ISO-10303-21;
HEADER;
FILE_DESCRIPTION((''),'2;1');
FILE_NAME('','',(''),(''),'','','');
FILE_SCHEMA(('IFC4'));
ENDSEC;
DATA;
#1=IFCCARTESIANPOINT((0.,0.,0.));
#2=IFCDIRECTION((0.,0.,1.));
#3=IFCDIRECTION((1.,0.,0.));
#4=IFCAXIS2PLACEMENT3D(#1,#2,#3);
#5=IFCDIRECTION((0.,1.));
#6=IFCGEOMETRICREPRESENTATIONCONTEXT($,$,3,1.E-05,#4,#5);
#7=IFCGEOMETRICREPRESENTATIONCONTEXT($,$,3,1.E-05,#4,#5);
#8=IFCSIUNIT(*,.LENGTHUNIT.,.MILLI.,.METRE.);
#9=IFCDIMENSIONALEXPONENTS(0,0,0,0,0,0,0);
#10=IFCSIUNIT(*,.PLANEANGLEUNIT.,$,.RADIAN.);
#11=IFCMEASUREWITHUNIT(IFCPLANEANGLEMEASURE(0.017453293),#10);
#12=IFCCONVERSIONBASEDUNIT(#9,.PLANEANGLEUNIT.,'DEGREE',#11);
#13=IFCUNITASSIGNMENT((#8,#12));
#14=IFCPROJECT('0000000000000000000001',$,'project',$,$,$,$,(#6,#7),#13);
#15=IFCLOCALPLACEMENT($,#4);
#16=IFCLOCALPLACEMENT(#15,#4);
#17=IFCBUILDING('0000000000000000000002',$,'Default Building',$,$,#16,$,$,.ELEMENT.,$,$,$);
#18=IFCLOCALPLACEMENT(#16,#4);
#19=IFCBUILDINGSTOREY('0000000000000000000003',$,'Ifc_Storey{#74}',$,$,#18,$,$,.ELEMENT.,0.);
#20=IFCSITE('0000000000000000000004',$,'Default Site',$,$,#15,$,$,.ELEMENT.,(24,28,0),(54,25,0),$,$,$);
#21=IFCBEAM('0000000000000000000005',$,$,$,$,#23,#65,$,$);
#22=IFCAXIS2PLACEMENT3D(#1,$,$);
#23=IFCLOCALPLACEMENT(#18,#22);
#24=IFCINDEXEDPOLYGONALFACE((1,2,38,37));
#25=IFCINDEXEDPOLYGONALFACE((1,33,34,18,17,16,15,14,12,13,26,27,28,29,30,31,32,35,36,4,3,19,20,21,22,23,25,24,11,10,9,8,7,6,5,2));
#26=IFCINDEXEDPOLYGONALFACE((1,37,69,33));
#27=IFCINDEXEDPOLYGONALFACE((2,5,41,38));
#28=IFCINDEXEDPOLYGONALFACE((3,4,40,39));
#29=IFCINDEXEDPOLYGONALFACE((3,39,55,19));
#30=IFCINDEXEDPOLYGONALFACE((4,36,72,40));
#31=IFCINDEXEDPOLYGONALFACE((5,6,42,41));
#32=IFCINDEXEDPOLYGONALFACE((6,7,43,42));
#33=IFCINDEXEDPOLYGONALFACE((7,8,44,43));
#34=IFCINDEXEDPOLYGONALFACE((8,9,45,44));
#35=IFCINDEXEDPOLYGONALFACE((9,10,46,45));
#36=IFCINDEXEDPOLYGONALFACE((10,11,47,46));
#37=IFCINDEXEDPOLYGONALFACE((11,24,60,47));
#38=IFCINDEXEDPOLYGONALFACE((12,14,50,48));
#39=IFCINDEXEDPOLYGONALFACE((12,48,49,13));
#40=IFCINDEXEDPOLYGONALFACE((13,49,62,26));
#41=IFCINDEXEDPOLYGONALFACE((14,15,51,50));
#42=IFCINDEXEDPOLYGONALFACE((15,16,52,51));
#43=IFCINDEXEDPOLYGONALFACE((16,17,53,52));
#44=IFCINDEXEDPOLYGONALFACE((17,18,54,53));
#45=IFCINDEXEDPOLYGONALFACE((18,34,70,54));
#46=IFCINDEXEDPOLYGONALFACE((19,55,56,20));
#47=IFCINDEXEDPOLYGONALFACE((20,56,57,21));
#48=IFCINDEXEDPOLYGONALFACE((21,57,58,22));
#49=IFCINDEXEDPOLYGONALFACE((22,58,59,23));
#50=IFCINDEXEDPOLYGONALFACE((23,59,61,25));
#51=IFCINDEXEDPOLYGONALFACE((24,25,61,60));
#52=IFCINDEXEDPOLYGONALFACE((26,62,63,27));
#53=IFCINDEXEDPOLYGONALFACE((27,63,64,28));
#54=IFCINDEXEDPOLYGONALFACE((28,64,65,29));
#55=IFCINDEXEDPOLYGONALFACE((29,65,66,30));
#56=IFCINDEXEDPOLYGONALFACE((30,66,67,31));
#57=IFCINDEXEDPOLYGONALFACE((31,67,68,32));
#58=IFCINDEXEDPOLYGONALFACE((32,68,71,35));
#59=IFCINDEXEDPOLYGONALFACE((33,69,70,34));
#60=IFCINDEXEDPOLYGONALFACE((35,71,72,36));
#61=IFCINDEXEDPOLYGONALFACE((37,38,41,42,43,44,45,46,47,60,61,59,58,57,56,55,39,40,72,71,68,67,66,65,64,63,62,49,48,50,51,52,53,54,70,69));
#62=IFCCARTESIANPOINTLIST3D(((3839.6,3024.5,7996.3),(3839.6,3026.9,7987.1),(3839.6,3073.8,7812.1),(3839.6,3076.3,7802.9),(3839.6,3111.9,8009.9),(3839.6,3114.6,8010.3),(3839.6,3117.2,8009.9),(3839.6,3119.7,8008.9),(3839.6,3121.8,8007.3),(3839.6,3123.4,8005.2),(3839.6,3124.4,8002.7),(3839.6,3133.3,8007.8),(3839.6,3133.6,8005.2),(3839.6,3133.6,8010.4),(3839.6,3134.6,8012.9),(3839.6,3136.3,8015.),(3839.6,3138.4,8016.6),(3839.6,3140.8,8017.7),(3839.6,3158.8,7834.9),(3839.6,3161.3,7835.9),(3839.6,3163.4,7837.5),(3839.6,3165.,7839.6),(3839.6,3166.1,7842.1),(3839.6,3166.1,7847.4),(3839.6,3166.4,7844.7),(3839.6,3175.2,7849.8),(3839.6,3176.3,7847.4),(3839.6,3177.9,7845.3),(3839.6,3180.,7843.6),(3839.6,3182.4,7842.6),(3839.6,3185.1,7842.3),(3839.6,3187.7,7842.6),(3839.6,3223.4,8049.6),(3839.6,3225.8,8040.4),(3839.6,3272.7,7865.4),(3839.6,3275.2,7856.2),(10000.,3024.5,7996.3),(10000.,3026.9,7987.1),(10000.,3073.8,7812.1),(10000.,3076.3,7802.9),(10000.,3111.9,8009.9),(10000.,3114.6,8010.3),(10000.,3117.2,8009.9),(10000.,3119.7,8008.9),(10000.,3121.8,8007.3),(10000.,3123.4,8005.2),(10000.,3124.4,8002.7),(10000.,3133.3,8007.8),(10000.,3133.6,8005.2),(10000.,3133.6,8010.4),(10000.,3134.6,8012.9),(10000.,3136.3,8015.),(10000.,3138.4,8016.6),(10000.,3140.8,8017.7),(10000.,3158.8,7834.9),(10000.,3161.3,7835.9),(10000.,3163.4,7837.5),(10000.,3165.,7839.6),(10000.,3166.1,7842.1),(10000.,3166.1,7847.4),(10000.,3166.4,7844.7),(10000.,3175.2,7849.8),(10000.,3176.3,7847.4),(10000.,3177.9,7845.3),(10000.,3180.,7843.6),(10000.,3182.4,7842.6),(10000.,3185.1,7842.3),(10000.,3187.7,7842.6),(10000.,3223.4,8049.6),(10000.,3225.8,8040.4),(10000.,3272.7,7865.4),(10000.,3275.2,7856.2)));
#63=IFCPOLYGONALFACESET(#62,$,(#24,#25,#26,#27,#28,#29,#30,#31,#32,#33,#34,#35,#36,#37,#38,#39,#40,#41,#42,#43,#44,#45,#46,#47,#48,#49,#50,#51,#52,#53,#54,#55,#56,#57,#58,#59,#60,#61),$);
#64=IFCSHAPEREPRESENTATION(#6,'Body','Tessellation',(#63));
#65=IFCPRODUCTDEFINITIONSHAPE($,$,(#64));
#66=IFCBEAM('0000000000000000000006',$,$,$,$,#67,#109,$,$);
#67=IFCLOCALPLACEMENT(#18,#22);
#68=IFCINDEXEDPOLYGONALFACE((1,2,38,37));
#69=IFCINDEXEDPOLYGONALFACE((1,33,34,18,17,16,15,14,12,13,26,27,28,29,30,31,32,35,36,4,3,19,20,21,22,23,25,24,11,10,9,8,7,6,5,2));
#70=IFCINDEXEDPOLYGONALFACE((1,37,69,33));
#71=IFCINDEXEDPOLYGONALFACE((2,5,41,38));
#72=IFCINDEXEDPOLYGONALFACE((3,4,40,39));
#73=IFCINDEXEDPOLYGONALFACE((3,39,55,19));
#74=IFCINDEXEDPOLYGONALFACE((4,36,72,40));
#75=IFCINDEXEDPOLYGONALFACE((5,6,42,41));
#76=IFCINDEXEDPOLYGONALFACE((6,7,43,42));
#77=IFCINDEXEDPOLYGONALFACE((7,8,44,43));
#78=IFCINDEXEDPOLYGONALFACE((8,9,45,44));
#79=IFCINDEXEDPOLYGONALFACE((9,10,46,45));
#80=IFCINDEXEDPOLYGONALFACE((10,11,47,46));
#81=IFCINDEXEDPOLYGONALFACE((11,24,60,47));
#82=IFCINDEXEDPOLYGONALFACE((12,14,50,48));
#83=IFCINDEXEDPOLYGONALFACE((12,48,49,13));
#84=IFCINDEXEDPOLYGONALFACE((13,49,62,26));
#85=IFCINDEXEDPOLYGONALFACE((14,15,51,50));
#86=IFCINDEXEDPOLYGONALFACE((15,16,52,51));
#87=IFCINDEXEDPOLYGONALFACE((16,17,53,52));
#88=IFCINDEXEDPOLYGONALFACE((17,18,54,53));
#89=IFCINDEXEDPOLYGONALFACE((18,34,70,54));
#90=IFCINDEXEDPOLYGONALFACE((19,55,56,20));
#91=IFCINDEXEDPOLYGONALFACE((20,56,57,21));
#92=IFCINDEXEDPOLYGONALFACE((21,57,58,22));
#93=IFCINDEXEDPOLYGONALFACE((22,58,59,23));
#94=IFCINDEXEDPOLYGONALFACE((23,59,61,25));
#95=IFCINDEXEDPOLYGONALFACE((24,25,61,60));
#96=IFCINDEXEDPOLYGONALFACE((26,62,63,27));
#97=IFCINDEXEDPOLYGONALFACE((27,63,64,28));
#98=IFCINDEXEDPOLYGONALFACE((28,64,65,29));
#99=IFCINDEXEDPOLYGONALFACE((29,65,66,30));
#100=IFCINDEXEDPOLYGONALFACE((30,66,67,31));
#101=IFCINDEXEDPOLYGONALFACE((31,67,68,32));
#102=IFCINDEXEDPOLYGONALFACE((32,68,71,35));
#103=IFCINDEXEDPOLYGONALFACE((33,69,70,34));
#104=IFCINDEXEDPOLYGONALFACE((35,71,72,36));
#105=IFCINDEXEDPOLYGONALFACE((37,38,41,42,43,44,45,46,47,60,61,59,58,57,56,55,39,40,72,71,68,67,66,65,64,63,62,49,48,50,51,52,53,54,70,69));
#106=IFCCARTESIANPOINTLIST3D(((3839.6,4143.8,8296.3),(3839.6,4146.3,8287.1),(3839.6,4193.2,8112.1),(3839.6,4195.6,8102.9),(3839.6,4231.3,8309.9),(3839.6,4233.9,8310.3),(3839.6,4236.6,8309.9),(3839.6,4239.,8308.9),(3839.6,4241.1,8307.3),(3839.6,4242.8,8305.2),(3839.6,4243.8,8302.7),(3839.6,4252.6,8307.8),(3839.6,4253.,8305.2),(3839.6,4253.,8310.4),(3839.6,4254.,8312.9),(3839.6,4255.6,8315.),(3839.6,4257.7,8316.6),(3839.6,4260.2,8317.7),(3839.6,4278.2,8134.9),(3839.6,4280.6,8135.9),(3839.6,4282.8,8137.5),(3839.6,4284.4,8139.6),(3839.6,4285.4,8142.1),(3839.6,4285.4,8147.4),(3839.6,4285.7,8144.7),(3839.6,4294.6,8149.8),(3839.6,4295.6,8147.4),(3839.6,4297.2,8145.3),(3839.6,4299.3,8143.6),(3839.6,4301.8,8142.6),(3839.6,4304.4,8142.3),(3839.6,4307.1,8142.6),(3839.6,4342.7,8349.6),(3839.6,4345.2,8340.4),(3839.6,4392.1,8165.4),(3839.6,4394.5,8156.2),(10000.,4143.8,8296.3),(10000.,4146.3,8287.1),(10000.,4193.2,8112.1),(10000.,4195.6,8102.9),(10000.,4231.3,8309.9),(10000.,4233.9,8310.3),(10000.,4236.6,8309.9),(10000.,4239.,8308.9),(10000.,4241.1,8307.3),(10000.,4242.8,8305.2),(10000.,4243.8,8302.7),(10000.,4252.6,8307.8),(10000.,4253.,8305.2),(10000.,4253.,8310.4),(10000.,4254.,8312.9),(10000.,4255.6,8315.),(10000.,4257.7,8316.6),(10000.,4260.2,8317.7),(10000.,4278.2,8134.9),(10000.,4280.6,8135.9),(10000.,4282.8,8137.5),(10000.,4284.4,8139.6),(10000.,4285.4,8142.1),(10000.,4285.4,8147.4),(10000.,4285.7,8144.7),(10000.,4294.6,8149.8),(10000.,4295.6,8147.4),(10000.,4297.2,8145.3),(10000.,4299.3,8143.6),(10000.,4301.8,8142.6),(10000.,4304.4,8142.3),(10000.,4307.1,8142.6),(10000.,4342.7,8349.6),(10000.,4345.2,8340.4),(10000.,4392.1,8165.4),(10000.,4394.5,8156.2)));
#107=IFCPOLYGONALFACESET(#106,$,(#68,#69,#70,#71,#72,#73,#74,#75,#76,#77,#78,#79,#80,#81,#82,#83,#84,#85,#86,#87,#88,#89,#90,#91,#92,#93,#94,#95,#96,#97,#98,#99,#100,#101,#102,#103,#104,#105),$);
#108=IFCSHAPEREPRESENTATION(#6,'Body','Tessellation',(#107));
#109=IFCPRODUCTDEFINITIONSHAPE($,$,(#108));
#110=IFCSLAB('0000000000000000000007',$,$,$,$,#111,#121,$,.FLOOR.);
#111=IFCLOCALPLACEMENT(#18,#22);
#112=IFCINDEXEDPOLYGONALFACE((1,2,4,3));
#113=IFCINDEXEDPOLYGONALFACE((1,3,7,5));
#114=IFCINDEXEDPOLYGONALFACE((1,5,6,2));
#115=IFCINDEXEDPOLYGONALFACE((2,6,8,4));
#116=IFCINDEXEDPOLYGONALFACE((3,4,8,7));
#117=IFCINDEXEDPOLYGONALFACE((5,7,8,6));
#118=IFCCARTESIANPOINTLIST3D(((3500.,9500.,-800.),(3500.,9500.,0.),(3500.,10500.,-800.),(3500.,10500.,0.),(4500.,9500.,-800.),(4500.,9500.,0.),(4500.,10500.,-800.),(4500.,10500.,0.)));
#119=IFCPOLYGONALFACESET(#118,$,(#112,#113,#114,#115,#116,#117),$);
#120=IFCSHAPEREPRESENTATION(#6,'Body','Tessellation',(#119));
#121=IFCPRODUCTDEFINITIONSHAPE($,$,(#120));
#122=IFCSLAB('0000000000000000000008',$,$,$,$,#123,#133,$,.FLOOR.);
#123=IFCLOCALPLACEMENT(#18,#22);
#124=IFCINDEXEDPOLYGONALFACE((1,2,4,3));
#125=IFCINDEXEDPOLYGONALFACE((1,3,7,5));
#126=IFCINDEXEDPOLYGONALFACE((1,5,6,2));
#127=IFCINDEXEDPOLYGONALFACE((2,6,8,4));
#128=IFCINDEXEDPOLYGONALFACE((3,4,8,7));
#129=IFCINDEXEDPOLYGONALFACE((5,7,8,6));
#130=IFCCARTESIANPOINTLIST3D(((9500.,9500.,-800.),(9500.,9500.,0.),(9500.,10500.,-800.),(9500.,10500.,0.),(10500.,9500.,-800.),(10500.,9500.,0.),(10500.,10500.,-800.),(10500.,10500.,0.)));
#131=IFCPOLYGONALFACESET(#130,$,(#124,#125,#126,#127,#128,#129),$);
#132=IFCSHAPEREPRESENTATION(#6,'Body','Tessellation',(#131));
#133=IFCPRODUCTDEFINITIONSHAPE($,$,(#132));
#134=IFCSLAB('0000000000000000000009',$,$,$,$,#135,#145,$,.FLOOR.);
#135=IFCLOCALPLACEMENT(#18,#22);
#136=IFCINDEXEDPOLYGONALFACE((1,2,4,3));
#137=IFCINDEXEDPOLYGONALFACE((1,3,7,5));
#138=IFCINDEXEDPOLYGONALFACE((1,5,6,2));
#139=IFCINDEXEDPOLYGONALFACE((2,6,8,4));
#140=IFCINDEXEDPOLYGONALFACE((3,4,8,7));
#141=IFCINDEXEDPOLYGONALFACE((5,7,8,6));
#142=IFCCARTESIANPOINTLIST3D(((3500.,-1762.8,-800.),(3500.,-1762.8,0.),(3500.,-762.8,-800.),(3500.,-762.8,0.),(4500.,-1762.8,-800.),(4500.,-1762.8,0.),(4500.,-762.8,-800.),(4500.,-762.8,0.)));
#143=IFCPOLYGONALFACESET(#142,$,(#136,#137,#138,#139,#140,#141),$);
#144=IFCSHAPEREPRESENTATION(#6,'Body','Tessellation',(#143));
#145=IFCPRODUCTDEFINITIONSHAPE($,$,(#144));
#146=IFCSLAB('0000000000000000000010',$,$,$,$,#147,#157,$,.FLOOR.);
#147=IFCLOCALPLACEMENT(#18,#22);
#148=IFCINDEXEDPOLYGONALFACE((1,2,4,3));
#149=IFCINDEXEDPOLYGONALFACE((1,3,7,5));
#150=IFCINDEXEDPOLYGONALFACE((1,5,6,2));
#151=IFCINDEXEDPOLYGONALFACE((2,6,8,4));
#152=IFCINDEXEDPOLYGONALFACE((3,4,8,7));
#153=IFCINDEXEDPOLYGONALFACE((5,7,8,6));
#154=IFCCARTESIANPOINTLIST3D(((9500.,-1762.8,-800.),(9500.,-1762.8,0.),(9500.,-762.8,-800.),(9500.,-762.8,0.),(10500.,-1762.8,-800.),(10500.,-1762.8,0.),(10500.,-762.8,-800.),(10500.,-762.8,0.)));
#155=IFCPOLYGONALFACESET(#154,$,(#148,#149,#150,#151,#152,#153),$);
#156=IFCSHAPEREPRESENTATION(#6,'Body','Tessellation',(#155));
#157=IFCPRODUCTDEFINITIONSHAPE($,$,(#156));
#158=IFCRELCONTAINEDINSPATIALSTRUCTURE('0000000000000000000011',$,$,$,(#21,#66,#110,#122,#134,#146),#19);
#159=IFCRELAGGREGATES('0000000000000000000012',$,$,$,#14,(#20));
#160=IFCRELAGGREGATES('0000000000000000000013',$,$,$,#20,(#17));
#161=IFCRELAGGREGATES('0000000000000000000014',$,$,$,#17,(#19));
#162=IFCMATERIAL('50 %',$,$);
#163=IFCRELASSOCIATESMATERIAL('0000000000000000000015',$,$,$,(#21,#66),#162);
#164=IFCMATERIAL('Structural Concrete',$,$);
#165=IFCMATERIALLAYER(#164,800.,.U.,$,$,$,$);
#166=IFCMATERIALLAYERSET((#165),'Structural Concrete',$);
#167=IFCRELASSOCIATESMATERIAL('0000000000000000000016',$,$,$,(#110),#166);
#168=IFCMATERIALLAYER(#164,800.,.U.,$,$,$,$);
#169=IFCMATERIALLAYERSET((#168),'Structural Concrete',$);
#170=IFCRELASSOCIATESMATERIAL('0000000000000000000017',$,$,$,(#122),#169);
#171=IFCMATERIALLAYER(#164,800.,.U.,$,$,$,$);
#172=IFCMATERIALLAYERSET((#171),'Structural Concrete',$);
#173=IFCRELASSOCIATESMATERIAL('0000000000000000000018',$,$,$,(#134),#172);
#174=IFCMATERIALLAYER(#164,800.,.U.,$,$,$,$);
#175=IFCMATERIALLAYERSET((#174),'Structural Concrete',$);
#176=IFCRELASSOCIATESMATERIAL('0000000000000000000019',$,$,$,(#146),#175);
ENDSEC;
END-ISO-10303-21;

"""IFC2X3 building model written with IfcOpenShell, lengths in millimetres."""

from ifc_helpers import new_model, entity, si_unit, converted_unit, direction, frame, origin_with_axes, origin_2d_with_axis, place, context, project, spatial, polyline, i_section, outline, extrude, material, layer, layer_set, layer_usage, element, save


model = new_model("IFC2X3")

# Units and contexts
context_of_model_1 = context(None, 3, precision=1e-05, world=origin_with_axes(), true_north=direction((0.0, 1.0)))
context_of_model_2 = context(None, 3, precision=1e-05, world=origin_with_axes(), true_north=direction((0.0, 1.0)))
ifc_project = project(units=[si_unit("LENGTHUNIT", "METRE", prefix="MILLI"), converted_unit("PLANEANGLEUNIT", "DEGREE", entity("IfcPlaneAngleMeasure", 0.017453293), si_unit("PLANEANGLEUNIT", "RADIAN"), dimensions=[0, 0, 0, 0, 0, 0, 0])], contexts=[context_of_model_1, context_of_model_2])

# Site, building, storey
site_placement = place(None, origin_with_axes())
site = spatial("IfcSite", under=ifc_project, at=site_placement, Name="Default Site", CompositionType="ELEMENT", RefLatitude=(24, 28, 0), RefLongitude=(54, 25, 0))
building_placement = place(site_placement, origin_with_axes())
building = spatial("IfcBuilding", under=site, at=building_placement, Name="Default Building", CompositionType="ELEMENT")
storey_placement = place(building_placement, origin_with_axes())
storey = spatial("IfcBuildingStorey", under=building, at=storey_placement, Name="Ifc_Storey{#74}", CompositionType="ELEMENT", Elevation=0.0)

# Shared definitions
ifc_material_1 = material(Name="50 %")

# Beams
for number, where, z_axis, x_axis in (
    (1, (3839.6, 3149.8, 7926.3), (0.0, -0.258819, 0.965926), (-1.0, 0.0, 0.0)),
    (2, (3839.6, 4269.2, 8226.3), (0.0, -0.258819, 0.965926), (-1.0, 0.0, 0.0)),
):
    element("IfcBeam", number, at=place(storey_placement, frame(where, z_axis=z_axis, x_axis=x_axis)), inside=storey, material=ifc_material_1, context=context_of_model_1, shape_type="SweptSolid", body=[
        extrude(i_section(OverallWidth=205.9, OverallDepth=200.2, WebThickness=9.5, FlangeThickness=9.5, FilletRadius=10.2, at=origin_2d_with_axis()), frame((0.0, 0.0, 0.0), z_axis=(-1.0, 0.0, 0.0), x_axis=(0.0, 1.0, 0.0)), (0.0, 0.0, 1.0), 6160.4),
    ])

# Slabs
ifc_material_2 = material(Name="Structural Concrete")
ifc_layer_1 = layer(ifc_material_2, 800.0, ventilated="UNKNOWN")
ifc_layer_set_1 = layer_set([ifc_layer_1], Name="Structural Concrete")
ifc_layer_usage_1 = layer_usage(ifc_layer_set_1, "AXIS3", "NEGATIVE", 800.0)
slab_1_placement = place(storey_placement, frame((3500.0, 10500.0, -800.0), z_axis=(0.0, 0.0, 1.0), x_axis=(0.0, -1.0, 0.0)))
element("IfcSlab", 3, at=slab_1_placement, inside=storey, material=ifc_layer_usage_1, PredefinedType="FLOOR", context=context_of_model_1, shape_type="SweptSolid", body=[
    extrude(outline(polyline([(0.0, 0.0), (1000.0, 0.0), (1000.0, 1000.0), (0.0, 1000.0), (0.0, 0.0)])), origin_with_axes(), (0.0, 0.0, 1.0), 800.0),
])
ifc_layer_2 = layer(ifc_material_2, 800.0, ventilated="UNKNOWN")
ifc_layer_set_2 = layer_set([ifc_layer_2], Name="Structural Concrete")
ifc_layer_usage_2 = layer_usage(ifc_layer_set_2, "AXIS3", "NEGATIVE", 800.0)
slab_2_placement = place(storey_placement, frame((9500.0, 10500.0, -800.0), z_axis=(0.0, 0.0, 1.0), x_axis=(0.0, -1.0, 0.0)))
element("IfcSlab", 4, at=slab_2_placement, inside=storey, material=ifc_layer_usage_2, PredefinedType="FLOOR", context=context_of_model_1, shape_type="SweptSolid", body=[
    extrude(outline(polyline([(0.0, 0.0), (1000.0, 0.0), (1000.0, 1000.0), (0.0, 1000.0), (0.0, 0.0)])), origin_with_axes(), (0.0, 0.0, 1.0), 800.0),
])
ifc_layer_3 = layer(ifc_material_2, 800.0, ventilated="UNKNOWN")
ifc_layer_set_3 = layer_set([ifc_layer_3], Name="Structural Concrete")
ifc_layer_usage_3 = layer_usage(ifc_layer_set_3, "AXIS3", "NEGATIVE", 800.0)
slab_3_placement = place(storey_placement, frame((3500.0, -1762.8, -800.0), z_axis=(0.0, 0.0, 1.0), x_axis=(0.0, 1.0, 0.0)))
element("IfcSlab", 5, at=slab_3_placement, inside=storey, material=ifc_layer_usage_3, PredefinedType="FLOOR", context=context_of_model_1, shape_type="SweptSolid", body=[
    extrude(outline(polyline([(0.0, 0.0), (1000.0, 0.0), (1000.0, -1000.0), (0.0, -1000.0), (0.0, 0.0)])), origin_with_axes(), (0.0, 0.0, 1.0), 800.0),
])
ifc_layer_4 = layer(ifc_material_2, 800.0, ventilated="UNKNOWN")
ifc_layer_set_4 = layer_set([ifc_layer_4], Name="Structural Concrete")
ifc_layer_usage_4 = layer_usage(ifc_layer_set_4, "AXIS3", "NEGATIVE", 800.0)
slab_4_placement = place(storey_placement, frame((9500.0, -1762.8, -800.0), z_axis=(0.0, 0.0, 1.0), x_axis=(0.0, 1.0, 0.0)))
element("IfcSlab", 6, at=slab_4_placement, inside=storey, material=ifc_layer_usage_4, PredefinedType="FLOOR", context=context_of_model_1, shape_type="SweptSolid", body=[
    extrude(outline(polyline([(0.0, 0.0), (1000.0, 0.0), (1000.0, -1000.0), (0.0, -1000.0), (0.0, 0.0)])), origin_with_axes(), (0.0, 0.0, 1.0), 800.0),
])

save(model, "model.ifc")
